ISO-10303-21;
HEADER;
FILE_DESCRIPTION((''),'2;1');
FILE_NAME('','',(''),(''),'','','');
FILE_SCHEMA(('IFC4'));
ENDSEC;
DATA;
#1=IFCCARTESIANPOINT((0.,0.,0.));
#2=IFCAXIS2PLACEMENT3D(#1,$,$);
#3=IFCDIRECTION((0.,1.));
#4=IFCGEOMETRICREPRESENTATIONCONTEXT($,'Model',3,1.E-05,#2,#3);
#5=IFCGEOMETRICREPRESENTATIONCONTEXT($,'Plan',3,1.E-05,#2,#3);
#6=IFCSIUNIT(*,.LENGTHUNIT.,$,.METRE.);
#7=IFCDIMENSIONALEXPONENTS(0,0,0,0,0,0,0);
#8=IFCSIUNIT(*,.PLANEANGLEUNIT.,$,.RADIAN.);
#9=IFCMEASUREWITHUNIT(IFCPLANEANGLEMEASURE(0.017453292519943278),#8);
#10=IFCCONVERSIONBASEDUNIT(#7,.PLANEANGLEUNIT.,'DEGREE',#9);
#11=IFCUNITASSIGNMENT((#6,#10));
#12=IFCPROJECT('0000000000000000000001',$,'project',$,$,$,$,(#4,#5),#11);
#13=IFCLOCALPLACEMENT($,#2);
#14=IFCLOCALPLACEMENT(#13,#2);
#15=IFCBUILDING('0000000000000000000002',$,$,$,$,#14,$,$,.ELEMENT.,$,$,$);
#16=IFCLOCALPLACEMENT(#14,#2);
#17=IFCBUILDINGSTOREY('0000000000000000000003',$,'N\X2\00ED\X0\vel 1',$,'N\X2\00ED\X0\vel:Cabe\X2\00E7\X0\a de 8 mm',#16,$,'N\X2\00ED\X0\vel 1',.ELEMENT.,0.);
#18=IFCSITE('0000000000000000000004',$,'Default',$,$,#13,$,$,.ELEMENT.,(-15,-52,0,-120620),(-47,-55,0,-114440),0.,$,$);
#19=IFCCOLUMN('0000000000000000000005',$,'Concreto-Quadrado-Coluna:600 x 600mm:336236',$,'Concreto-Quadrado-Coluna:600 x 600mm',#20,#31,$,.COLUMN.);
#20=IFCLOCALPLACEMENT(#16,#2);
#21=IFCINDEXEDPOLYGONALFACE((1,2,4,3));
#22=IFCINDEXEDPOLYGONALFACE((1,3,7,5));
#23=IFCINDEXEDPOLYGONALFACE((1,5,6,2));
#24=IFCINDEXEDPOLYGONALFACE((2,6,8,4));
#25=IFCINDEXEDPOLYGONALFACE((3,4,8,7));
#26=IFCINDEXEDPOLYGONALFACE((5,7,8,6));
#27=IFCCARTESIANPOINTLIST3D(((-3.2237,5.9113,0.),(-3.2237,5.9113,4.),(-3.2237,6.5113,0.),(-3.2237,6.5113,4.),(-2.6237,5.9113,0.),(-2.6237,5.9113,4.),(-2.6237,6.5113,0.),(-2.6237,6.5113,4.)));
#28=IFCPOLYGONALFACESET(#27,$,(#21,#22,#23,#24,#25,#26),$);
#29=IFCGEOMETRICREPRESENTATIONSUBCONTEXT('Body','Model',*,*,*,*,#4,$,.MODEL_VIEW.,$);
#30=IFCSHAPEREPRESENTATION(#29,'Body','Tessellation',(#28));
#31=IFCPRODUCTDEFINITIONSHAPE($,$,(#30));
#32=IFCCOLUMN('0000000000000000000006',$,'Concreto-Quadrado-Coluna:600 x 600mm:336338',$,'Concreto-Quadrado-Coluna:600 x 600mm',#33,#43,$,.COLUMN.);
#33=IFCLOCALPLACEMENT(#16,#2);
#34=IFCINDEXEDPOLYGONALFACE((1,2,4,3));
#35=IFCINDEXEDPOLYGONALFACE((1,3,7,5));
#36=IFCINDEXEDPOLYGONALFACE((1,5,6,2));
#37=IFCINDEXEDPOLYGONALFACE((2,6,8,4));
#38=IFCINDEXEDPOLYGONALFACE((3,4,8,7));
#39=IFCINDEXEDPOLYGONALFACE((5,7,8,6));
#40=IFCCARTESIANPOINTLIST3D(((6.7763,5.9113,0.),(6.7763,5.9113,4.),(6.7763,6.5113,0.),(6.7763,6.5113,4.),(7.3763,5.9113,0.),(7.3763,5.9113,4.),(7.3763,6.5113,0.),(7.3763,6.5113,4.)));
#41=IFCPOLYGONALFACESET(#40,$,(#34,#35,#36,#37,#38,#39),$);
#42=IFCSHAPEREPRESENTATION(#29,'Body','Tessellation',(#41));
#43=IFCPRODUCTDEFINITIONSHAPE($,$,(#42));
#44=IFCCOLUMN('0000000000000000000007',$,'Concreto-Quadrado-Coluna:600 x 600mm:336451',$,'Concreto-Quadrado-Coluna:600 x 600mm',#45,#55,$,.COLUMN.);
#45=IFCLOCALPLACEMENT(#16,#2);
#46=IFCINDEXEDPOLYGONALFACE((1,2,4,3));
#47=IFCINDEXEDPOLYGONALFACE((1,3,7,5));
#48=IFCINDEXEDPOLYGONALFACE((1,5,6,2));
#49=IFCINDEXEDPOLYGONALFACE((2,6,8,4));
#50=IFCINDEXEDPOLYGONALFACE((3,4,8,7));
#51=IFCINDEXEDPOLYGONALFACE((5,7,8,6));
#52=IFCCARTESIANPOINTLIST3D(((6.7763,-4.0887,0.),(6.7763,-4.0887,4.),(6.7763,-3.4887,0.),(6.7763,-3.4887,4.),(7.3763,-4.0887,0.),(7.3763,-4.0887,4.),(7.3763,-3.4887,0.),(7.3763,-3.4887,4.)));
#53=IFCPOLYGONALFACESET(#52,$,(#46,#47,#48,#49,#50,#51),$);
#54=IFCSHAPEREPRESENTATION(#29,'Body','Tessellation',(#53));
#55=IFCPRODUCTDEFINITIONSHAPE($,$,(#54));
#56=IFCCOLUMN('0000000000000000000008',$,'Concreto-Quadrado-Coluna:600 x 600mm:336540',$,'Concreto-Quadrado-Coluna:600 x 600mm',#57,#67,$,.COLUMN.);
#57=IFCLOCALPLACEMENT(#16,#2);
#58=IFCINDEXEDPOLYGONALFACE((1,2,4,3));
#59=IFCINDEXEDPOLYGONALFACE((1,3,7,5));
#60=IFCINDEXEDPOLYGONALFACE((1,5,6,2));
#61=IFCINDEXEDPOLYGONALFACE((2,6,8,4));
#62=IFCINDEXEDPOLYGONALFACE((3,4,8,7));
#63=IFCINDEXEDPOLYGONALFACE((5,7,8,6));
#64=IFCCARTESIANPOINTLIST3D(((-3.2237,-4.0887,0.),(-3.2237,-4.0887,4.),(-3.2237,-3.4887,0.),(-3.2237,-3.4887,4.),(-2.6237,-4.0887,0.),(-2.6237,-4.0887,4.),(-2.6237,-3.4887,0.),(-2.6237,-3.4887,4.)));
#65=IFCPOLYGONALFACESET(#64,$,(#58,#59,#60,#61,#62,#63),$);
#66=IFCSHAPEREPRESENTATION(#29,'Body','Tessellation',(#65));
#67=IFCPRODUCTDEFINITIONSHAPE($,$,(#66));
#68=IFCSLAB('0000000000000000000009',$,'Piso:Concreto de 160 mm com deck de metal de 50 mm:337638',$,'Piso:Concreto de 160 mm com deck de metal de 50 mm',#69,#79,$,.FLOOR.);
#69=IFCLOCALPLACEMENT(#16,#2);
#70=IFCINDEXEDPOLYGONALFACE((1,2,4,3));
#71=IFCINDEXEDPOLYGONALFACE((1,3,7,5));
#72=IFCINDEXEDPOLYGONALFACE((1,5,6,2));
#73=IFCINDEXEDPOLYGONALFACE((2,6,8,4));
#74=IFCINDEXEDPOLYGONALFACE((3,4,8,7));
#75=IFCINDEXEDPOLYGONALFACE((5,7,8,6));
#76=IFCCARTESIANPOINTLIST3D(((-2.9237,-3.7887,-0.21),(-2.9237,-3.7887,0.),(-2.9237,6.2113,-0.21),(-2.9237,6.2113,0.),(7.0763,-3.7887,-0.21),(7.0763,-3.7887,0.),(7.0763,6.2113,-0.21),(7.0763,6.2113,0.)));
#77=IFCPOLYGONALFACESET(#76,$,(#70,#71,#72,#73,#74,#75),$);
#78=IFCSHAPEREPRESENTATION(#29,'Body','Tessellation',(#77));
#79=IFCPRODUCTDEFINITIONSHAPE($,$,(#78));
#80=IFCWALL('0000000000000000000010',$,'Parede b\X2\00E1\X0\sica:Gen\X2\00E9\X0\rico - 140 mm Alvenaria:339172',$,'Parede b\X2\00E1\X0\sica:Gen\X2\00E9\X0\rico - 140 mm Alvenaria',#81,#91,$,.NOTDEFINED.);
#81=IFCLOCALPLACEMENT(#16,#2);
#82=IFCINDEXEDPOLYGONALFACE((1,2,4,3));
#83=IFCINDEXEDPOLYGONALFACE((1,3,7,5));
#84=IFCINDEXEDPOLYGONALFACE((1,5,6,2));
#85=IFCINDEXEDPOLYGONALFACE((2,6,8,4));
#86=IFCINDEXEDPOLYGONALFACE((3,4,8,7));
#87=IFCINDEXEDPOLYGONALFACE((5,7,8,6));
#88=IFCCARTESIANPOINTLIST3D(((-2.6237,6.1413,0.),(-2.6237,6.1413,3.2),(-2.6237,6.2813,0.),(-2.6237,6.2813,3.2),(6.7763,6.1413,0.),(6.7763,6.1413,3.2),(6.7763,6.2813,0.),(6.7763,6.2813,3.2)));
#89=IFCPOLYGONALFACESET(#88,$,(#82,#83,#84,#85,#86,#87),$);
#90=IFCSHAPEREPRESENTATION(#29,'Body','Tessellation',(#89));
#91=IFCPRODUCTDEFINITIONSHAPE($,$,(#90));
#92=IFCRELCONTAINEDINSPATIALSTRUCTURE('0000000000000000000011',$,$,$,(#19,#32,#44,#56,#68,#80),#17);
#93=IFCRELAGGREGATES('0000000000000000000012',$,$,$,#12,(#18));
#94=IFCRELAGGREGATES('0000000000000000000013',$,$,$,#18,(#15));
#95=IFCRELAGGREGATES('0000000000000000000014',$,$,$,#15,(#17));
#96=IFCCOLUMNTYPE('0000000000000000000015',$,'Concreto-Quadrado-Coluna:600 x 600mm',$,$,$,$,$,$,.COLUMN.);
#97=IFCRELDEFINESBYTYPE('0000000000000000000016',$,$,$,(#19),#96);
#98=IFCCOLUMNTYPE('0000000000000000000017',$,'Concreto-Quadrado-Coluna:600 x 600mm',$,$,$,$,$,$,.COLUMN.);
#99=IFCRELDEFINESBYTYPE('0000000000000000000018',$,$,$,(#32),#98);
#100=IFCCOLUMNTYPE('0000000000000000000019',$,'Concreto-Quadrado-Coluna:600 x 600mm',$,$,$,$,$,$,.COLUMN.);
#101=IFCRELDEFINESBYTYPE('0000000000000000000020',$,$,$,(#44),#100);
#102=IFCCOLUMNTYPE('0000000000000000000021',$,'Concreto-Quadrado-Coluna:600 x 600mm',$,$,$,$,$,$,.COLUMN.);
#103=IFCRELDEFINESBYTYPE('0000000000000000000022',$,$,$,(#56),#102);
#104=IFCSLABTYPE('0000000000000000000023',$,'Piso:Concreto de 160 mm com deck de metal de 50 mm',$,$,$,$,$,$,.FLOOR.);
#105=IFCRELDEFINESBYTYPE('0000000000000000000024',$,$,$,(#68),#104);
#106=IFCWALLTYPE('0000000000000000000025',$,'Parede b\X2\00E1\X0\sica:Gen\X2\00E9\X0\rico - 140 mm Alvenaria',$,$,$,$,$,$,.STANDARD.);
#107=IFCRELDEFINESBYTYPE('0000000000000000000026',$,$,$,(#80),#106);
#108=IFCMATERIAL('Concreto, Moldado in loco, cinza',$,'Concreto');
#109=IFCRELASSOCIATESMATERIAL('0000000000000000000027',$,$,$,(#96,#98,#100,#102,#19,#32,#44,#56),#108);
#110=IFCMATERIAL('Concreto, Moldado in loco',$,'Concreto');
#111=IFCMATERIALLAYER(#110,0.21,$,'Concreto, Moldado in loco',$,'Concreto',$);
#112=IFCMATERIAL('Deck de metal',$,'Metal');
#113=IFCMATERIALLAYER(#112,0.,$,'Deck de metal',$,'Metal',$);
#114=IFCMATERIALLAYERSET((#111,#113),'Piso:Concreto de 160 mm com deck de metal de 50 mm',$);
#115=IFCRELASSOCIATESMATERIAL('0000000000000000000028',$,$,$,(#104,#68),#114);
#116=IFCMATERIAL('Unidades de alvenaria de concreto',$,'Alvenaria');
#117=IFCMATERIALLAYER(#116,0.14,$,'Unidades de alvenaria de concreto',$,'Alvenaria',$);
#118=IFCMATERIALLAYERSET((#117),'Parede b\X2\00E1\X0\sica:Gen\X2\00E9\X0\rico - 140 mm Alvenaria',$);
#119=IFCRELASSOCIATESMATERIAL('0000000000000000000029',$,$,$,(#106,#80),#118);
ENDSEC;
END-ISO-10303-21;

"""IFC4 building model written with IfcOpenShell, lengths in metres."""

from ifc_helpers import new_model, entity, si_unit, converted_unit, direction, frame, frame_2d, origin, origin_2d_with_axis, place, context, subcontext, project, spatial, rectangle, extrude, source, transform, mapped, material, layer, layer_set, layer_usage, material_profile, profile_set, profile_usage, type_object, type_shapes, element, save


model = new_model("IFC4")

# Units and contexts
model_context = context("Model", 3, precision=1e-05, world=origin(), true_north=direction((0.0, 1.0)))
plan_context = context("Plan", 3, precision=1e-05, world=origin(), true_north=direction((0.0, 1.0)))
body_context = subcontext(model_context, "Body", "Model", "MODEL_VIEW")
ifc_project = project(units=[si_unit("LENGTHUNIT", "METRE"), converted_unit("PLANEANGLEUNIT", "DEGREE", entity("IfcPlaneAngleMeasure", 0.017453292519943278), si_unit("PLANEANGLEUNIT", "RADIAN"), dimensions=[0, 0, 0, 0, 0, 0, 0])], contexts=[model_context, plan_context])

# Site, building, storey
site_placement = place(None, origin())
site = spatial("IfcSite", under=ifc_project, at=site_placement, Name="Default", CompositionType="ELEMENT", RefLatitude=(-15, -52, 0, -120620), RefLongitude=(-47, -55, 0, -114440), RefElevation=0.0)
building_placement = place(site_placement, origin())
building = spatial("IfcBuilding", under=site, at=building_placement, CompositionType="ELEMENT")
storey_placement = place(building_placement, origin())
storey = spatial("IfcBuildingStorey", under=building, at=storey_placement, Name="Nível 1", ObjectType="Nível:Cabeça de 8 mm", LongName="Nível 1", CompositionType="ELEMENT", Elevation=0.0)

# Columns
ifc_material_1 = material(Name="Concreto, Moldado in loco, cinza", Category="Concreto")
ifc_material_profile_1 = material_profile(ifc_material_1, rectangle(XDim=0.6, YDim=0.6, at=origin_2d_with_axis()), Name="600 x 600mm")
ifc_profile_set_1 = profile_set([ifc_material_profile_1], Name="600 x 600mm")
ifc_profile_usage_1 = profile_usage(ifc_profile_set_1)
column_type_1 = type_object("IfcColumnType", Name="Concreto-Quadrado-Coluna:600 x 600mm", PredefinedType="COLUMN", material=ifc_profile_set_1)
shared_shape_1 = source(origin(), body_context, "Body", "SweptSolid", [
    extrude(rectangle(XDim=0.6, YDim=0.6, at=origin_2d_with_axis()), frame((-2.9237, 6.2113, 0.0), z_axis=(0.0, 0.0, 1.0), x_axis=(-1.0, 0.0, 0.0)), (0.0, 0.0, 1.0), 4.0),
])
type_shapes(column_type_1, [shared_shape_1])
column_1_placement = place(storey_placement, origin())
element("IfcColumn", 1, at=column_1_placement, inside=storey, type_object=column_type_1, material=ifc_profile_usage_1, Name="Concreto-Quadrado-Coluna:600 x 600mm:336236", ObjectType="Concreto-Quadrado-Coluna:600 x 600mm", PredefinedType="COLUMN", context=body_context, shape_type="MappedRepresentation", body=[
    mapped(shared_shape_1, transform((0.0, 0.0, 0.0), scale=1.0)),
])
column_type_2 = type_object("IfcColumnType", Name="Concreto-Quadrado-Coluna:600 x 600mm", PredefinedType="COLUMN", material=ifc_profile_set_1)
shared_shape_2 = source(origin(), body_context, "Body", "SweptSolid", [
    extrude(rectangle(XDim=0.6, YDim=0.6, at=origin_2d_with_axis()), frame((7.0763, 6.2113, 0.0), z_axis=(0.0, 0.0, 1.0), x_axis=(-1.0, 0.0, 0.0)), (0.0, 0.0, 1.0), 4.0),
])
type_shapes(column_type_2, [shared_shape_2])
column_2_placement = place(storey_placement, origin())
element("IfcColumn", 2, at=column_2_placement, inside=storey, type_object=column_type_2, material=ifc_profile_usage_1, Name="Concreto-Quadrado-Coluna:600 x 600mm:336338", ObjectType="Concreto-Quadrado-Coluna:600 x 600mm", PredefinedType="COLUMN", context=body_context, shape_type="MappedRepresentation", body=[
    mapped(shared_shape_2, transform((0.0, 0.0, 0.0), scale=1.0)),
])
column_type_3 = type_object("IfcColumnType", Name="Concreto-Quadrado-Coluna:600 x 600mm", PredefinedType="COLUMN", material=ifc_profile_set_1)
shared_shape_3 = source(origin(), body_context, "Body", "SweptSolid", [
    extrude(rectangle(XDim=0.6, YDim=0.6, at=origin_2d_with_axis()), frame((7.0763, -3.7887, 0.0), z_axis=(0.0, 0.0, 1.0), x_axis=(-1.0, 0.0, 0.0)), (0.0, 0.0, 1.0), 4.0),
])
type_shapes(column_type_3, [shared_shape_3])
column_3_placement = place(storey_placement, origin())
element("IfcColumn", 3, at=column_3_placement, inside=storey, type_object=column_type_3, material=ifc_profile_usage_1, Name="Concreto-Quadrado-Coluna:600 x 600mm:336451", ObjectType="Concreto-Quadrado-Coluna:600 x 600mm", PredefinedType="COLUMN", context=body_context, shape_type="MappedRepresentation", body=[
    mapped(shared_shape_3, transform((0.0, 0.0, 0.0), scale=1.0)),
])
column_type_4 = type_object("IfcColumnType", Name="Concreto-Quadrado-Coluna:600 x 600mm", PredefinedType="COLUMN", material=ifc_profile_set_1)
shared_shape_4 = source(origin(), body_context, "Body", "SweptSolid", [
    extrude(rectangle(XDim=0.6, YDim=0.6, at=origin_2d_with_axis()), frame((-2.9237, -3.7887, 0.0), z_axis=(0.0, 0.0, 1.0), x_axis=(-1.0, 0.0, 0.0)), (0.0, 0.0, 1.0), 4.0),
])
type_shapes(column_type_4, [shared_shape_4])
column_4_placement = place(storey_placement, origin())
element("IfcColumn", 4, at=column_4_placement, inside=storey, type_object=column_type_4, material=ifc_profile_usage_1, Name="Concreto-Quadrado-Coluna:600 x 600mm:336540", ObjectType="Concreto-Quadrado-Coluna:600 x 600mm", PredefinedType="COLUMN", context=body_context, shape_type="MappedRepresentation", body=[
    mapped(shared_shape_4, transform((0.0, 0.0, 0.0), scale=1.0)),
])

# Slab
ifc_material_2 = material(Name="Concreto, Moldado in loco", Category="Concreto")
ifc_layer_1 = layer(ifc_material_2, 0.21, Name="Concreto, Moldado in loco", Category="Concreto")
ifc_material_3 = material(Name="Deck de metal", Category="Metal")
ifc_layer_2 = layer(ifc_material_3, 0.0, Name="Deck de metal", Category="Metal")
ifc_layer_set_1 = layer_set([ifc_layer_1, ifc_layer_2], Name="Piso:Concreto de 160 mm com deck de metal de 50 mm")
ifc_layer_usage_1 = layer_usage(ifc_layer_set_1, "AXIS3", "POSITIVE", 0.0)
slab_type = type_object("IfcSlabType", Name="Piso:Concreto de 160 mm com deck de metal de 50 mm", PredefinedType="FLOOR", material=ifc_layer_set_1)
slab_placement = place(storey_placement, origin())
element("IfcSlab", 5, at=slab_placement, inside=storey, type_object=slab_type, material=ifc_layer_usage_1, Name="Piso:Concreto de 160 mm com deck de metal de 50 mm:337638", ObjectType="Piso:Concreto de 160 mm com deck de metal de 50 mm", PredefinedType="FLOOR", context=body_context, shape_type="SweptSolid", body=[
    extrude(rectangle(XDim=10.0, YDim=10.0, at=frame_2d((0.0, 0.0), x_axis=(1.0, 0.0))), frame((2.0763, 1.2113, 0.0), z_axis=(0.0, 0.0, -1.0), x_axis=(0.0, 1.0, 0.0)), (0.0, 0.0, 1.0), 0.21),
])

# Shared definitions
ifc_material_4 = material(Name="Unidades de alvenaria de concreto", Category="Alvenaria")
ifc_layer_3 = layer(ifc_material_4, 0.14, Name="Unidades de alvenaria de concreto", Category="Alvenaria")
ifc_layer_set_2 = layer_set([ifc_layer_3], Name="Parede básica:Genérico - 140 mm Alvenaria")
wall_type = type_object("IfcWallType", Name="Parede básica:Genérico - 140 mm Alvenaria", PredefinedType="STANDARD", material=ifc_layer_set_2)

# Wall
ifc_layer_usage_2 = layer_usage(ifc_layer_set_2, "AXIS2", "NEGATIVE", 0.07)
wall_1_placement = place(storey_placement, frame((-2.6237, 6.2113, 0.0)))
element("IfcWall", 6, at=wall_1_placement, inside=storey, type_object=wall_type, material=ifc_layer_usage_2, Name="Parede básica:Genérico - 140 mm Alvenaria:339172", ObjectType="Parede básica:Genérico - 140 mm Alvenaria", PredefinedType="NOTDEFINED", context=body_context, shape_type="SweptSolid", body=[
    extrude(rectangle(XDim=9.4, YDim=0.14, at=frame_2d((4.7, 0.0), x_axis=(-1.0, 0.0))), origin(), (0.0, 0.0, 1.0), 3.2),
])

save(model, "model.ifc")
